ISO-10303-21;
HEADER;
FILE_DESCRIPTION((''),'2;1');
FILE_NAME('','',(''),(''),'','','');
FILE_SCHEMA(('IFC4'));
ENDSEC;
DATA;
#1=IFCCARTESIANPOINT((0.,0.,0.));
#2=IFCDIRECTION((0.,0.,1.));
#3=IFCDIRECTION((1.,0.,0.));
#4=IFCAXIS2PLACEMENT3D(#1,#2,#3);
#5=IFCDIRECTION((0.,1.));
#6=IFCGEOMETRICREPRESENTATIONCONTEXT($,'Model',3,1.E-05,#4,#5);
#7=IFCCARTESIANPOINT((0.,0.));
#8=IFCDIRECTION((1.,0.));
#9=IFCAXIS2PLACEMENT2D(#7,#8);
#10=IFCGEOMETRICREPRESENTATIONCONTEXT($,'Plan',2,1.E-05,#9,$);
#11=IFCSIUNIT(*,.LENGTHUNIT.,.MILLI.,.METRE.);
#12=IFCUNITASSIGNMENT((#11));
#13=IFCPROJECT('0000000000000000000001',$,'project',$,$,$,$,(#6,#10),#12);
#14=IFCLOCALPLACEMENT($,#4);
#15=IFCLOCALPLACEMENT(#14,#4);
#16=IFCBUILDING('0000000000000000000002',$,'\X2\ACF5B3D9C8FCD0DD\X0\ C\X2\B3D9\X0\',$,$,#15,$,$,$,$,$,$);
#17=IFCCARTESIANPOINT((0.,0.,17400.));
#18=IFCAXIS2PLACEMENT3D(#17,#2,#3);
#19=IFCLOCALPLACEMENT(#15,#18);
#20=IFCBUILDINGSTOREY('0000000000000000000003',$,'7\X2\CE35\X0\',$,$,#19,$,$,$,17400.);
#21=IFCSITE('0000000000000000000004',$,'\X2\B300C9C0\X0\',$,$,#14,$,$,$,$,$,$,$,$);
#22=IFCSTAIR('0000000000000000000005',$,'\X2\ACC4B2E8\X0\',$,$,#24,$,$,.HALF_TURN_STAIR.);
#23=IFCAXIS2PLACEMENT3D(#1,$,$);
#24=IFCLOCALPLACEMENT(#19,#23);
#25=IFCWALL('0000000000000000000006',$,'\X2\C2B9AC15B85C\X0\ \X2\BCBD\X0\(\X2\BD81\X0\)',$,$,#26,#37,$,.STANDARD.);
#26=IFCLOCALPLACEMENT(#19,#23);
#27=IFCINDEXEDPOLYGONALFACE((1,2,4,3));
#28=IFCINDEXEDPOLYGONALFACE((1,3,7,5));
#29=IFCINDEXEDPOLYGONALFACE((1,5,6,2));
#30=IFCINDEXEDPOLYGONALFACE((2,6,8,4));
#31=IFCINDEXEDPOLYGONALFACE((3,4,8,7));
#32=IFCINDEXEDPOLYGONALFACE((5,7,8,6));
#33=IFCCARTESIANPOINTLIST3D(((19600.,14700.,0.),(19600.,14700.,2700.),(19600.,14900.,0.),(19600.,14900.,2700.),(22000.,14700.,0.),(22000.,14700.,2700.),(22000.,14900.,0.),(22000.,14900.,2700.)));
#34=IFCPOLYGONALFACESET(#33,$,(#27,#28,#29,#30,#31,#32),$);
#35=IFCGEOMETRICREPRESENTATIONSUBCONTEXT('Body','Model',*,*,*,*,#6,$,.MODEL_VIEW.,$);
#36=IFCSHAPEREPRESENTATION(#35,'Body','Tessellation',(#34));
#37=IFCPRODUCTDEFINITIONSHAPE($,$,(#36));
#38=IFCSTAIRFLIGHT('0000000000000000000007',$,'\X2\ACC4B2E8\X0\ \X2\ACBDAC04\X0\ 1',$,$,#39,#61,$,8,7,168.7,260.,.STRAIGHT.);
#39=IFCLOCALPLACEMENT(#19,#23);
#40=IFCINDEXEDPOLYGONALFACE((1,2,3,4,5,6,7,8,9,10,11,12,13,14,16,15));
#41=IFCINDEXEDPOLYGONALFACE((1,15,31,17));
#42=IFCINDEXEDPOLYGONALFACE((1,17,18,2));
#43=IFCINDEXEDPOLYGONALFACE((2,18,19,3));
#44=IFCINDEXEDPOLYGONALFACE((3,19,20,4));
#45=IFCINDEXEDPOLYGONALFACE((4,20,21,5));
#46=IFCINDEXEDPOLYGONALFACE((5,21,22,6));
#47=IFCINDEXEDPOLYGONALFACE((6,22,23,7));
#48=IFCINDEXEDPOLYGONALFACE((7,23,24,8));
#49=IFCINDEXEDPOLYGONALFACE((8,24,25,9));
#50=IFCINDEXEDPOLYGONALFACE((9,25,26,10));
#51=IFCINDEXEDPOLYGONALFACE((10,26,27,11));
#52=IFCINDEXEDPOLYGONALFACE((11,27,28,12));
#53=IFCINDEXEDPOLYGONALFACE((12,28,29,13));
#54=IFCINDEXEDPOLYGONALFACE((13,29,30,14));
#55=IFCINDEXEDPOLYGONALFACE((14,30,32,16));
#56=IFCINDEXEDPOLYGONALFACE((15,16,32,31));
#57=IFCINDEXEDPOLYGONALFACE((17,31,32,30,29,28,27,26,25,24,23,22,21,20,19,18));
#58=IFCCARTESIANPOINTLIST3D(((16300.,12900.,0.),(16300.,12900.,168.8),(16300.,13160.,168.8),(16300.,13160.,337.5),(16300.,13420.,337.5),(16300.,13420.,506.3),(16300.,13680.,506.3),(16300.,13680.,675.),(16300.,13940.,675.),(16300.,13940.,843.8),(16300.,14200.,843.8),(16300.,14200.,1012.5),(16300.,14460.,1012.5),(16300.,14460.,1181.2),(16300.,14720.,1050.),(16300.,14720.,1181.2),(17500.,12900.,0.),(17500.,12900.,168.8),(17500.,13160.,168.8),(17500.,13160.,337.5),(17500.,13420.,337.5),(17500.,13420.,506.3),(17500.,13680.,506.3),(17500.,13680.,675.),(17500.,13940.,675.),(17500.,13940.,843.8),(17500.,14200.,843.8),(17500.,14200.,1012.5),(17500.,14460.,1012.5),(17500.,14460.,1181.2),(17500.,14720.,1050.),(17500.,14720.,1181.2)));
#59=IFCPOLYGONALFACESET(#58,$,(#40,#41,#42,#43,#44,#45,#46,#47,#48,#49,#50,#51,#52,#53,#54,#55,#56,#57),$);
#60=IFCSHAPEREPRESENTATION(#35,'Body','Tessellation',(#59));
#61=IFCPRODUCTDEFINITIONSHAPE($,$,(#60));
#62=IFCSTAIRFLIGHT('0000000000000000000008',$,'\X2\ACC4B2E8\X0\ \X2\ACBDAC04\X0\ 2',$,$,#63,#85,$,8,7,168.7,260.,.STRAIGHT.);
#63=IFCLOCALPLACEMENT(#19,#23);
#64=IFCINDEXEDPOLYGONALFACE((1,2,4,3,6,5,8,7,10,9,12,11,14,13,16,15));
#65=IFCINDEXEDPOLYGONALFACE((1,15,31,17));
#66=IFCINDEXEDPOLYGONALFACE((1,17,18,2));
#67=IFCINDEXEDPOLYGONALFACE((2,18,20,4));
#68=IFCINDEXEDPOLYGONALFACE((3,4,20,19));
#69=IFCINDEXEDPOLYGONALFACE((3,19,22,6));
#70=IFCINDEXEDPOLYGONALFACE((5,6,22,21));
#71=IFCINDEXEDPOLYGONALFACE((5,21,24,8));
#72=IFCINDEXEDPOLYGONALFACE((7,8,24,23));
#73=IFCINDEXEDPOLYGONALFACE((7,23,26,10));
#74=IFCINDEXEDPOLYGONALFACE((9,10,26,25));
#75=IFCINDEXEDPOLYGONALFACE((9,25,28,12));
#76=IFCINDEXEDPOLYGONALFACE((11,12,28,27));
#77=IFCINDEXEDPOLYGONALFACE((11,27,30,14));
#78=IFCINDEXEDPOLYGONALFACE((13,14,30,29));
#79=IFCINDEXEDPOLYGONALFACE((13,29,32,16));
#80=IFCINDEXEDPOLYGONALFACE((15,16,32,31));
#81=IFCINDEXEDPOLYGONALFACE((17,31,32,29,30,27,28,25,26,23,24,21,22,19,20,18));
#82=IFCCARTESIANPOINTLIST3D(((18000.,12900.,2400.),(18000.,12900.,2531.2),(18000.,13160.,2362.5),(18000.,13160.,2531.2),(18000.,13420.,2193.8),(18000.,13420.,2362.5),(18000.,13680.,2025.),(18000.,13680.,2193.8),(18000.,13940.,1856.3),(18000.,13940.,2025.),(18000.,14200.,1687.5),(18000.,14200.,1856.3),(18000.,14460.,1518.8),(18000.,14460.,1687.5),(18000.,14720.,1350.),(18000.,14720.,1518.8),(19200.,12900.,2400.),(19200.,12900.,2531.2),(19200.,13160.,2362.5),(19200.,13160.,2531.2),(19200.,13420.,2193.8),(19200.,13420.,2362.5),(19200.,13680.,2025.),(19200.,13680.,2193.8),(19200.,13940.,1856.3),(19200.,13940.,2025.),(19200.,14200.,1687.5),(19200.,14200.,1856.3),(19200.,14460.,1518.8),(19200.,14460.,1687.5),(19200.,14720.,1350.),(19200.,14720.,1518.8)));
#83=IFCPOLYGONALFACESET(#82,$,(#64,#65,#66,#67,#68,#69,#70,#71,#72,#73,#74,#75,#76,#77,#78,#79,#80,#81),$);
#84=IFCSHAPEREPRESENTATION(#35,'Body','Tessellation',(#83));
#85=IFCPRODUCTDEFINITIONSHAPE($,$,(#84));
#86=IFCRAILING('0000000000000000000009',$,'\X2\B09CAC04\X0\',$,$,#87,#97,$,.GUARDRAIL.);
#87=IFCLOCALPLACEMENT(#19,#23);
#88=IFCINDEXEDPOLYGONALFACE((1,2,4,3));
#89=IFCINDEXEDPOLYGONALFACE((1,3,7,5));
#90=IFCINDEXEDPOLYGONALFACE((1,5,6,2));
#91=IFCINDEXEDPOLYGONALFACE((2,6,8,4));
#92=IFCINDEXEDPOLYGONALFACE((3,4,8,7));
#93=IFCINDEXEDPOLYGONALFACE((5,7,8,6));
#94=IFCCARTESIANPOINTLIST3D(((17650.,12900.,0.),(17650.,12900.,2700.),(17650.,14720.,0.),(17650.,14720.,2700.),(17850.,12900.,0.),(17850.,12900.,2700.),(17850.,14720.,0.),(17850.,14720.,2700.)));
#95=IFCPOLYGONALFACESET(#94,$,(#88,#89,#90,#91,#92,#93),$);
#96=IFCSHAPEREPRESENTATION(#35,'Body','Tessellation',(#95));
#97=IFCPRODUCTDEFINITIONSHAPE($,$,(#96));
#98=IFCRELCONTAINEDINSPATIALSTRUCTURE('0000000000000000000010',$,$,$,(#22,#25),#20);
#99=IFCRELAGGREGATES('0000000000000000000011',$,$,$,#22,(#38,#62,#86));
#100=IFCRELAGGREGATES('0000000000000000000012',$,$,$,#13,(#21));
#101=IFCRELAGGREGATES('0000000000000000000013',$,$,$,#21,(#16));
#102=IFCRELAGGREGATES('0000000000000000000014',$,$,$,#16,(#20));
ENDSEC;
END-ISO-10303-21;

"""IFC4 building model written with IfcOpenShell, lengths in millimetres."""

from ifc_helpers import new_model, si_unit, direction, frame, origin_with_axes, origin_2d_with_axis, place, context, subcontext, project, spatial, polyline, outline, extrude, element, aggregate, save


model = new_model("IFC4")

# Units and contexts
model_context = context("Model", 3, precision=1e-05, world=origin_with_axes(), true_north=direction((0.0, 1.0)))
plan_context = context("Plan", 2, precision=1e-05, world=origin_2d_with_axis())
body_context = subcontext(model_context, "Body", "Model", "MODEL_VIEW")
ifc_project = project(units=[si_unit("LENGTHUNIT", "METRE", prefix="MILLI")], contexts=[model_context, plan_context])

# Site, building, storey
site_placement = place(None, origin_with_axes())
site = spatial("IfcSite", under=ifc_project, at=site_placement, Name="대지")
building_placement = place(site_placement, origin_with_axes())
building = spatial("IfcBuilding", under=site, at=building_placement, Name="공동주택 C동")
storey_placement = place(building_placement, frame((0.0, 0.0, 17400.0), z_axis=(0.0, 0.0, 1.0), x_axis=(1.0, 0.0, 0.0)))
storey = spatial("IfcBuildingStorey", under=building, at=storey_placement, Name="7층", Elevation=17400.0)

# Stair
stair_placement = place(storey_placement, origin_with_axes())
stair = element("IfcStair", 1, at=stair_placement, inside=storey, Name="계단", PredefinedType="HALF_TURN_STAIR")

# Wall
wall_1_placement = place(storey_placement, origin_with_axes())
element("IfcWall", 2, at=wall_1_placement, inside=storey, Name="승강로 벽(북)", PredefinedType="STANDARD", context=body_context, shape_type="SweptSolid", body=[
    extrude(outline(polyline([(19600.0, 14900.0), (22000.0, 14900.0), (22000.0, 14700.0), (19600.0, 14700.0), (19600.0, 14900.0)])), origin_with_axes(), (0.0, 0.0, 1.0), 2700.0),
])

# Stair flights
stair_flight_1_placement = place(stair_placement, origin_with_axes())
stair_flight_1 = element("IfcStairFlight", 3, at=stair_flight_1_placement, Name="계단 경간 1", NumberOfRisers=8, NumberOfTreads=7, PredefinedType="STRAIGHT", RiserHeight=168.7, TreadLength=260.0, context=body_context, shape_type="SweptSolid", body=[
    extrude(outline(polyline([(0.0, 0.0), (0.0, 168.7), (260.0, 168.7), (260.0, 337.5), (520.0, 337.5), (520.0, 506.2), (780.0, 506.2), (780.0, 675.0), (1040.0, 675.0), (1040.0, 843.7), (1300.0, 843.7), (1300.0, 1012.5), (1560.0, 1012.5), (1560.0, 1181.2), (1820.0, 1181.2), (1820.0, 1350.0), (1820.0, 1050.0), (0.0, 0.0)])), frame((16300.0, 12900.0, 0.0), z_axis=(1.0, 0.0, 0.0), x_axis=(0.0, 1.0, 0.0)), (0.0, 0.0, 1.0), 1200.0),
])
stair_flight_2_placement = place(stair_placement, origin_with_axes())
stair_flight_2 = element("IfcStairFlight", 4, at=stair_flight_2_placement, Name="계단 경간 2", NumberOfRisers=8, NumberOfTreads=7, PredefinedType="STRAIGHT", RiserHeight=168.7, TreadLength=260.0, context=body_context, shape_type="SweptSolid", body=[
    extrude(outline(polyline([(0.0, 0.0), (0.0, 168.7), (260.0, 168.7), (260.0, 337.5), (520.0, 337.5), (520.0, 506.2), (780.0, 506.2), (780.0, 675.0), (1040.0, 675.0), (1040.0, 843.7), (1300.0, 843.7), (1300.0, 1012.5), (1560.0, 1012.5), (1560.0, 1181.2), (1820.0, 1181.2), (1820.0, 1350.0), (1820.0, 1050.0), (0.0, 0.0)])), frame((19200.0, 14720.0, 1350.0), z_axis=(-1.0, 0.0, 0.0), x_axis=(0.0, -1.0, 0.0)), (0.0, 0.0, 1.0), 1200.0),
])

# Railing
railing_placement = place(stair_placement, origin_with_axes())
railing = element("IfcRailing", 5, at=railing_placement, Name="난간", PredefinedType="GUARDRAIL", context=body_context, shape_type="SweptSolid", body=[
    extrude(outline(polyline([(17650.0, 12900.0), (17850.0, 12900.0), (17850.0, 14720.0), (17650.0, 14720.0), (17650.0, 12900.0)])), origin_with_axes(), (0.0, 0.0, 1.0), 2700.0),
])
aggregate(stair, [stair_flight_1, stair_flight_2, railing])

save(model, "model.ifc")
